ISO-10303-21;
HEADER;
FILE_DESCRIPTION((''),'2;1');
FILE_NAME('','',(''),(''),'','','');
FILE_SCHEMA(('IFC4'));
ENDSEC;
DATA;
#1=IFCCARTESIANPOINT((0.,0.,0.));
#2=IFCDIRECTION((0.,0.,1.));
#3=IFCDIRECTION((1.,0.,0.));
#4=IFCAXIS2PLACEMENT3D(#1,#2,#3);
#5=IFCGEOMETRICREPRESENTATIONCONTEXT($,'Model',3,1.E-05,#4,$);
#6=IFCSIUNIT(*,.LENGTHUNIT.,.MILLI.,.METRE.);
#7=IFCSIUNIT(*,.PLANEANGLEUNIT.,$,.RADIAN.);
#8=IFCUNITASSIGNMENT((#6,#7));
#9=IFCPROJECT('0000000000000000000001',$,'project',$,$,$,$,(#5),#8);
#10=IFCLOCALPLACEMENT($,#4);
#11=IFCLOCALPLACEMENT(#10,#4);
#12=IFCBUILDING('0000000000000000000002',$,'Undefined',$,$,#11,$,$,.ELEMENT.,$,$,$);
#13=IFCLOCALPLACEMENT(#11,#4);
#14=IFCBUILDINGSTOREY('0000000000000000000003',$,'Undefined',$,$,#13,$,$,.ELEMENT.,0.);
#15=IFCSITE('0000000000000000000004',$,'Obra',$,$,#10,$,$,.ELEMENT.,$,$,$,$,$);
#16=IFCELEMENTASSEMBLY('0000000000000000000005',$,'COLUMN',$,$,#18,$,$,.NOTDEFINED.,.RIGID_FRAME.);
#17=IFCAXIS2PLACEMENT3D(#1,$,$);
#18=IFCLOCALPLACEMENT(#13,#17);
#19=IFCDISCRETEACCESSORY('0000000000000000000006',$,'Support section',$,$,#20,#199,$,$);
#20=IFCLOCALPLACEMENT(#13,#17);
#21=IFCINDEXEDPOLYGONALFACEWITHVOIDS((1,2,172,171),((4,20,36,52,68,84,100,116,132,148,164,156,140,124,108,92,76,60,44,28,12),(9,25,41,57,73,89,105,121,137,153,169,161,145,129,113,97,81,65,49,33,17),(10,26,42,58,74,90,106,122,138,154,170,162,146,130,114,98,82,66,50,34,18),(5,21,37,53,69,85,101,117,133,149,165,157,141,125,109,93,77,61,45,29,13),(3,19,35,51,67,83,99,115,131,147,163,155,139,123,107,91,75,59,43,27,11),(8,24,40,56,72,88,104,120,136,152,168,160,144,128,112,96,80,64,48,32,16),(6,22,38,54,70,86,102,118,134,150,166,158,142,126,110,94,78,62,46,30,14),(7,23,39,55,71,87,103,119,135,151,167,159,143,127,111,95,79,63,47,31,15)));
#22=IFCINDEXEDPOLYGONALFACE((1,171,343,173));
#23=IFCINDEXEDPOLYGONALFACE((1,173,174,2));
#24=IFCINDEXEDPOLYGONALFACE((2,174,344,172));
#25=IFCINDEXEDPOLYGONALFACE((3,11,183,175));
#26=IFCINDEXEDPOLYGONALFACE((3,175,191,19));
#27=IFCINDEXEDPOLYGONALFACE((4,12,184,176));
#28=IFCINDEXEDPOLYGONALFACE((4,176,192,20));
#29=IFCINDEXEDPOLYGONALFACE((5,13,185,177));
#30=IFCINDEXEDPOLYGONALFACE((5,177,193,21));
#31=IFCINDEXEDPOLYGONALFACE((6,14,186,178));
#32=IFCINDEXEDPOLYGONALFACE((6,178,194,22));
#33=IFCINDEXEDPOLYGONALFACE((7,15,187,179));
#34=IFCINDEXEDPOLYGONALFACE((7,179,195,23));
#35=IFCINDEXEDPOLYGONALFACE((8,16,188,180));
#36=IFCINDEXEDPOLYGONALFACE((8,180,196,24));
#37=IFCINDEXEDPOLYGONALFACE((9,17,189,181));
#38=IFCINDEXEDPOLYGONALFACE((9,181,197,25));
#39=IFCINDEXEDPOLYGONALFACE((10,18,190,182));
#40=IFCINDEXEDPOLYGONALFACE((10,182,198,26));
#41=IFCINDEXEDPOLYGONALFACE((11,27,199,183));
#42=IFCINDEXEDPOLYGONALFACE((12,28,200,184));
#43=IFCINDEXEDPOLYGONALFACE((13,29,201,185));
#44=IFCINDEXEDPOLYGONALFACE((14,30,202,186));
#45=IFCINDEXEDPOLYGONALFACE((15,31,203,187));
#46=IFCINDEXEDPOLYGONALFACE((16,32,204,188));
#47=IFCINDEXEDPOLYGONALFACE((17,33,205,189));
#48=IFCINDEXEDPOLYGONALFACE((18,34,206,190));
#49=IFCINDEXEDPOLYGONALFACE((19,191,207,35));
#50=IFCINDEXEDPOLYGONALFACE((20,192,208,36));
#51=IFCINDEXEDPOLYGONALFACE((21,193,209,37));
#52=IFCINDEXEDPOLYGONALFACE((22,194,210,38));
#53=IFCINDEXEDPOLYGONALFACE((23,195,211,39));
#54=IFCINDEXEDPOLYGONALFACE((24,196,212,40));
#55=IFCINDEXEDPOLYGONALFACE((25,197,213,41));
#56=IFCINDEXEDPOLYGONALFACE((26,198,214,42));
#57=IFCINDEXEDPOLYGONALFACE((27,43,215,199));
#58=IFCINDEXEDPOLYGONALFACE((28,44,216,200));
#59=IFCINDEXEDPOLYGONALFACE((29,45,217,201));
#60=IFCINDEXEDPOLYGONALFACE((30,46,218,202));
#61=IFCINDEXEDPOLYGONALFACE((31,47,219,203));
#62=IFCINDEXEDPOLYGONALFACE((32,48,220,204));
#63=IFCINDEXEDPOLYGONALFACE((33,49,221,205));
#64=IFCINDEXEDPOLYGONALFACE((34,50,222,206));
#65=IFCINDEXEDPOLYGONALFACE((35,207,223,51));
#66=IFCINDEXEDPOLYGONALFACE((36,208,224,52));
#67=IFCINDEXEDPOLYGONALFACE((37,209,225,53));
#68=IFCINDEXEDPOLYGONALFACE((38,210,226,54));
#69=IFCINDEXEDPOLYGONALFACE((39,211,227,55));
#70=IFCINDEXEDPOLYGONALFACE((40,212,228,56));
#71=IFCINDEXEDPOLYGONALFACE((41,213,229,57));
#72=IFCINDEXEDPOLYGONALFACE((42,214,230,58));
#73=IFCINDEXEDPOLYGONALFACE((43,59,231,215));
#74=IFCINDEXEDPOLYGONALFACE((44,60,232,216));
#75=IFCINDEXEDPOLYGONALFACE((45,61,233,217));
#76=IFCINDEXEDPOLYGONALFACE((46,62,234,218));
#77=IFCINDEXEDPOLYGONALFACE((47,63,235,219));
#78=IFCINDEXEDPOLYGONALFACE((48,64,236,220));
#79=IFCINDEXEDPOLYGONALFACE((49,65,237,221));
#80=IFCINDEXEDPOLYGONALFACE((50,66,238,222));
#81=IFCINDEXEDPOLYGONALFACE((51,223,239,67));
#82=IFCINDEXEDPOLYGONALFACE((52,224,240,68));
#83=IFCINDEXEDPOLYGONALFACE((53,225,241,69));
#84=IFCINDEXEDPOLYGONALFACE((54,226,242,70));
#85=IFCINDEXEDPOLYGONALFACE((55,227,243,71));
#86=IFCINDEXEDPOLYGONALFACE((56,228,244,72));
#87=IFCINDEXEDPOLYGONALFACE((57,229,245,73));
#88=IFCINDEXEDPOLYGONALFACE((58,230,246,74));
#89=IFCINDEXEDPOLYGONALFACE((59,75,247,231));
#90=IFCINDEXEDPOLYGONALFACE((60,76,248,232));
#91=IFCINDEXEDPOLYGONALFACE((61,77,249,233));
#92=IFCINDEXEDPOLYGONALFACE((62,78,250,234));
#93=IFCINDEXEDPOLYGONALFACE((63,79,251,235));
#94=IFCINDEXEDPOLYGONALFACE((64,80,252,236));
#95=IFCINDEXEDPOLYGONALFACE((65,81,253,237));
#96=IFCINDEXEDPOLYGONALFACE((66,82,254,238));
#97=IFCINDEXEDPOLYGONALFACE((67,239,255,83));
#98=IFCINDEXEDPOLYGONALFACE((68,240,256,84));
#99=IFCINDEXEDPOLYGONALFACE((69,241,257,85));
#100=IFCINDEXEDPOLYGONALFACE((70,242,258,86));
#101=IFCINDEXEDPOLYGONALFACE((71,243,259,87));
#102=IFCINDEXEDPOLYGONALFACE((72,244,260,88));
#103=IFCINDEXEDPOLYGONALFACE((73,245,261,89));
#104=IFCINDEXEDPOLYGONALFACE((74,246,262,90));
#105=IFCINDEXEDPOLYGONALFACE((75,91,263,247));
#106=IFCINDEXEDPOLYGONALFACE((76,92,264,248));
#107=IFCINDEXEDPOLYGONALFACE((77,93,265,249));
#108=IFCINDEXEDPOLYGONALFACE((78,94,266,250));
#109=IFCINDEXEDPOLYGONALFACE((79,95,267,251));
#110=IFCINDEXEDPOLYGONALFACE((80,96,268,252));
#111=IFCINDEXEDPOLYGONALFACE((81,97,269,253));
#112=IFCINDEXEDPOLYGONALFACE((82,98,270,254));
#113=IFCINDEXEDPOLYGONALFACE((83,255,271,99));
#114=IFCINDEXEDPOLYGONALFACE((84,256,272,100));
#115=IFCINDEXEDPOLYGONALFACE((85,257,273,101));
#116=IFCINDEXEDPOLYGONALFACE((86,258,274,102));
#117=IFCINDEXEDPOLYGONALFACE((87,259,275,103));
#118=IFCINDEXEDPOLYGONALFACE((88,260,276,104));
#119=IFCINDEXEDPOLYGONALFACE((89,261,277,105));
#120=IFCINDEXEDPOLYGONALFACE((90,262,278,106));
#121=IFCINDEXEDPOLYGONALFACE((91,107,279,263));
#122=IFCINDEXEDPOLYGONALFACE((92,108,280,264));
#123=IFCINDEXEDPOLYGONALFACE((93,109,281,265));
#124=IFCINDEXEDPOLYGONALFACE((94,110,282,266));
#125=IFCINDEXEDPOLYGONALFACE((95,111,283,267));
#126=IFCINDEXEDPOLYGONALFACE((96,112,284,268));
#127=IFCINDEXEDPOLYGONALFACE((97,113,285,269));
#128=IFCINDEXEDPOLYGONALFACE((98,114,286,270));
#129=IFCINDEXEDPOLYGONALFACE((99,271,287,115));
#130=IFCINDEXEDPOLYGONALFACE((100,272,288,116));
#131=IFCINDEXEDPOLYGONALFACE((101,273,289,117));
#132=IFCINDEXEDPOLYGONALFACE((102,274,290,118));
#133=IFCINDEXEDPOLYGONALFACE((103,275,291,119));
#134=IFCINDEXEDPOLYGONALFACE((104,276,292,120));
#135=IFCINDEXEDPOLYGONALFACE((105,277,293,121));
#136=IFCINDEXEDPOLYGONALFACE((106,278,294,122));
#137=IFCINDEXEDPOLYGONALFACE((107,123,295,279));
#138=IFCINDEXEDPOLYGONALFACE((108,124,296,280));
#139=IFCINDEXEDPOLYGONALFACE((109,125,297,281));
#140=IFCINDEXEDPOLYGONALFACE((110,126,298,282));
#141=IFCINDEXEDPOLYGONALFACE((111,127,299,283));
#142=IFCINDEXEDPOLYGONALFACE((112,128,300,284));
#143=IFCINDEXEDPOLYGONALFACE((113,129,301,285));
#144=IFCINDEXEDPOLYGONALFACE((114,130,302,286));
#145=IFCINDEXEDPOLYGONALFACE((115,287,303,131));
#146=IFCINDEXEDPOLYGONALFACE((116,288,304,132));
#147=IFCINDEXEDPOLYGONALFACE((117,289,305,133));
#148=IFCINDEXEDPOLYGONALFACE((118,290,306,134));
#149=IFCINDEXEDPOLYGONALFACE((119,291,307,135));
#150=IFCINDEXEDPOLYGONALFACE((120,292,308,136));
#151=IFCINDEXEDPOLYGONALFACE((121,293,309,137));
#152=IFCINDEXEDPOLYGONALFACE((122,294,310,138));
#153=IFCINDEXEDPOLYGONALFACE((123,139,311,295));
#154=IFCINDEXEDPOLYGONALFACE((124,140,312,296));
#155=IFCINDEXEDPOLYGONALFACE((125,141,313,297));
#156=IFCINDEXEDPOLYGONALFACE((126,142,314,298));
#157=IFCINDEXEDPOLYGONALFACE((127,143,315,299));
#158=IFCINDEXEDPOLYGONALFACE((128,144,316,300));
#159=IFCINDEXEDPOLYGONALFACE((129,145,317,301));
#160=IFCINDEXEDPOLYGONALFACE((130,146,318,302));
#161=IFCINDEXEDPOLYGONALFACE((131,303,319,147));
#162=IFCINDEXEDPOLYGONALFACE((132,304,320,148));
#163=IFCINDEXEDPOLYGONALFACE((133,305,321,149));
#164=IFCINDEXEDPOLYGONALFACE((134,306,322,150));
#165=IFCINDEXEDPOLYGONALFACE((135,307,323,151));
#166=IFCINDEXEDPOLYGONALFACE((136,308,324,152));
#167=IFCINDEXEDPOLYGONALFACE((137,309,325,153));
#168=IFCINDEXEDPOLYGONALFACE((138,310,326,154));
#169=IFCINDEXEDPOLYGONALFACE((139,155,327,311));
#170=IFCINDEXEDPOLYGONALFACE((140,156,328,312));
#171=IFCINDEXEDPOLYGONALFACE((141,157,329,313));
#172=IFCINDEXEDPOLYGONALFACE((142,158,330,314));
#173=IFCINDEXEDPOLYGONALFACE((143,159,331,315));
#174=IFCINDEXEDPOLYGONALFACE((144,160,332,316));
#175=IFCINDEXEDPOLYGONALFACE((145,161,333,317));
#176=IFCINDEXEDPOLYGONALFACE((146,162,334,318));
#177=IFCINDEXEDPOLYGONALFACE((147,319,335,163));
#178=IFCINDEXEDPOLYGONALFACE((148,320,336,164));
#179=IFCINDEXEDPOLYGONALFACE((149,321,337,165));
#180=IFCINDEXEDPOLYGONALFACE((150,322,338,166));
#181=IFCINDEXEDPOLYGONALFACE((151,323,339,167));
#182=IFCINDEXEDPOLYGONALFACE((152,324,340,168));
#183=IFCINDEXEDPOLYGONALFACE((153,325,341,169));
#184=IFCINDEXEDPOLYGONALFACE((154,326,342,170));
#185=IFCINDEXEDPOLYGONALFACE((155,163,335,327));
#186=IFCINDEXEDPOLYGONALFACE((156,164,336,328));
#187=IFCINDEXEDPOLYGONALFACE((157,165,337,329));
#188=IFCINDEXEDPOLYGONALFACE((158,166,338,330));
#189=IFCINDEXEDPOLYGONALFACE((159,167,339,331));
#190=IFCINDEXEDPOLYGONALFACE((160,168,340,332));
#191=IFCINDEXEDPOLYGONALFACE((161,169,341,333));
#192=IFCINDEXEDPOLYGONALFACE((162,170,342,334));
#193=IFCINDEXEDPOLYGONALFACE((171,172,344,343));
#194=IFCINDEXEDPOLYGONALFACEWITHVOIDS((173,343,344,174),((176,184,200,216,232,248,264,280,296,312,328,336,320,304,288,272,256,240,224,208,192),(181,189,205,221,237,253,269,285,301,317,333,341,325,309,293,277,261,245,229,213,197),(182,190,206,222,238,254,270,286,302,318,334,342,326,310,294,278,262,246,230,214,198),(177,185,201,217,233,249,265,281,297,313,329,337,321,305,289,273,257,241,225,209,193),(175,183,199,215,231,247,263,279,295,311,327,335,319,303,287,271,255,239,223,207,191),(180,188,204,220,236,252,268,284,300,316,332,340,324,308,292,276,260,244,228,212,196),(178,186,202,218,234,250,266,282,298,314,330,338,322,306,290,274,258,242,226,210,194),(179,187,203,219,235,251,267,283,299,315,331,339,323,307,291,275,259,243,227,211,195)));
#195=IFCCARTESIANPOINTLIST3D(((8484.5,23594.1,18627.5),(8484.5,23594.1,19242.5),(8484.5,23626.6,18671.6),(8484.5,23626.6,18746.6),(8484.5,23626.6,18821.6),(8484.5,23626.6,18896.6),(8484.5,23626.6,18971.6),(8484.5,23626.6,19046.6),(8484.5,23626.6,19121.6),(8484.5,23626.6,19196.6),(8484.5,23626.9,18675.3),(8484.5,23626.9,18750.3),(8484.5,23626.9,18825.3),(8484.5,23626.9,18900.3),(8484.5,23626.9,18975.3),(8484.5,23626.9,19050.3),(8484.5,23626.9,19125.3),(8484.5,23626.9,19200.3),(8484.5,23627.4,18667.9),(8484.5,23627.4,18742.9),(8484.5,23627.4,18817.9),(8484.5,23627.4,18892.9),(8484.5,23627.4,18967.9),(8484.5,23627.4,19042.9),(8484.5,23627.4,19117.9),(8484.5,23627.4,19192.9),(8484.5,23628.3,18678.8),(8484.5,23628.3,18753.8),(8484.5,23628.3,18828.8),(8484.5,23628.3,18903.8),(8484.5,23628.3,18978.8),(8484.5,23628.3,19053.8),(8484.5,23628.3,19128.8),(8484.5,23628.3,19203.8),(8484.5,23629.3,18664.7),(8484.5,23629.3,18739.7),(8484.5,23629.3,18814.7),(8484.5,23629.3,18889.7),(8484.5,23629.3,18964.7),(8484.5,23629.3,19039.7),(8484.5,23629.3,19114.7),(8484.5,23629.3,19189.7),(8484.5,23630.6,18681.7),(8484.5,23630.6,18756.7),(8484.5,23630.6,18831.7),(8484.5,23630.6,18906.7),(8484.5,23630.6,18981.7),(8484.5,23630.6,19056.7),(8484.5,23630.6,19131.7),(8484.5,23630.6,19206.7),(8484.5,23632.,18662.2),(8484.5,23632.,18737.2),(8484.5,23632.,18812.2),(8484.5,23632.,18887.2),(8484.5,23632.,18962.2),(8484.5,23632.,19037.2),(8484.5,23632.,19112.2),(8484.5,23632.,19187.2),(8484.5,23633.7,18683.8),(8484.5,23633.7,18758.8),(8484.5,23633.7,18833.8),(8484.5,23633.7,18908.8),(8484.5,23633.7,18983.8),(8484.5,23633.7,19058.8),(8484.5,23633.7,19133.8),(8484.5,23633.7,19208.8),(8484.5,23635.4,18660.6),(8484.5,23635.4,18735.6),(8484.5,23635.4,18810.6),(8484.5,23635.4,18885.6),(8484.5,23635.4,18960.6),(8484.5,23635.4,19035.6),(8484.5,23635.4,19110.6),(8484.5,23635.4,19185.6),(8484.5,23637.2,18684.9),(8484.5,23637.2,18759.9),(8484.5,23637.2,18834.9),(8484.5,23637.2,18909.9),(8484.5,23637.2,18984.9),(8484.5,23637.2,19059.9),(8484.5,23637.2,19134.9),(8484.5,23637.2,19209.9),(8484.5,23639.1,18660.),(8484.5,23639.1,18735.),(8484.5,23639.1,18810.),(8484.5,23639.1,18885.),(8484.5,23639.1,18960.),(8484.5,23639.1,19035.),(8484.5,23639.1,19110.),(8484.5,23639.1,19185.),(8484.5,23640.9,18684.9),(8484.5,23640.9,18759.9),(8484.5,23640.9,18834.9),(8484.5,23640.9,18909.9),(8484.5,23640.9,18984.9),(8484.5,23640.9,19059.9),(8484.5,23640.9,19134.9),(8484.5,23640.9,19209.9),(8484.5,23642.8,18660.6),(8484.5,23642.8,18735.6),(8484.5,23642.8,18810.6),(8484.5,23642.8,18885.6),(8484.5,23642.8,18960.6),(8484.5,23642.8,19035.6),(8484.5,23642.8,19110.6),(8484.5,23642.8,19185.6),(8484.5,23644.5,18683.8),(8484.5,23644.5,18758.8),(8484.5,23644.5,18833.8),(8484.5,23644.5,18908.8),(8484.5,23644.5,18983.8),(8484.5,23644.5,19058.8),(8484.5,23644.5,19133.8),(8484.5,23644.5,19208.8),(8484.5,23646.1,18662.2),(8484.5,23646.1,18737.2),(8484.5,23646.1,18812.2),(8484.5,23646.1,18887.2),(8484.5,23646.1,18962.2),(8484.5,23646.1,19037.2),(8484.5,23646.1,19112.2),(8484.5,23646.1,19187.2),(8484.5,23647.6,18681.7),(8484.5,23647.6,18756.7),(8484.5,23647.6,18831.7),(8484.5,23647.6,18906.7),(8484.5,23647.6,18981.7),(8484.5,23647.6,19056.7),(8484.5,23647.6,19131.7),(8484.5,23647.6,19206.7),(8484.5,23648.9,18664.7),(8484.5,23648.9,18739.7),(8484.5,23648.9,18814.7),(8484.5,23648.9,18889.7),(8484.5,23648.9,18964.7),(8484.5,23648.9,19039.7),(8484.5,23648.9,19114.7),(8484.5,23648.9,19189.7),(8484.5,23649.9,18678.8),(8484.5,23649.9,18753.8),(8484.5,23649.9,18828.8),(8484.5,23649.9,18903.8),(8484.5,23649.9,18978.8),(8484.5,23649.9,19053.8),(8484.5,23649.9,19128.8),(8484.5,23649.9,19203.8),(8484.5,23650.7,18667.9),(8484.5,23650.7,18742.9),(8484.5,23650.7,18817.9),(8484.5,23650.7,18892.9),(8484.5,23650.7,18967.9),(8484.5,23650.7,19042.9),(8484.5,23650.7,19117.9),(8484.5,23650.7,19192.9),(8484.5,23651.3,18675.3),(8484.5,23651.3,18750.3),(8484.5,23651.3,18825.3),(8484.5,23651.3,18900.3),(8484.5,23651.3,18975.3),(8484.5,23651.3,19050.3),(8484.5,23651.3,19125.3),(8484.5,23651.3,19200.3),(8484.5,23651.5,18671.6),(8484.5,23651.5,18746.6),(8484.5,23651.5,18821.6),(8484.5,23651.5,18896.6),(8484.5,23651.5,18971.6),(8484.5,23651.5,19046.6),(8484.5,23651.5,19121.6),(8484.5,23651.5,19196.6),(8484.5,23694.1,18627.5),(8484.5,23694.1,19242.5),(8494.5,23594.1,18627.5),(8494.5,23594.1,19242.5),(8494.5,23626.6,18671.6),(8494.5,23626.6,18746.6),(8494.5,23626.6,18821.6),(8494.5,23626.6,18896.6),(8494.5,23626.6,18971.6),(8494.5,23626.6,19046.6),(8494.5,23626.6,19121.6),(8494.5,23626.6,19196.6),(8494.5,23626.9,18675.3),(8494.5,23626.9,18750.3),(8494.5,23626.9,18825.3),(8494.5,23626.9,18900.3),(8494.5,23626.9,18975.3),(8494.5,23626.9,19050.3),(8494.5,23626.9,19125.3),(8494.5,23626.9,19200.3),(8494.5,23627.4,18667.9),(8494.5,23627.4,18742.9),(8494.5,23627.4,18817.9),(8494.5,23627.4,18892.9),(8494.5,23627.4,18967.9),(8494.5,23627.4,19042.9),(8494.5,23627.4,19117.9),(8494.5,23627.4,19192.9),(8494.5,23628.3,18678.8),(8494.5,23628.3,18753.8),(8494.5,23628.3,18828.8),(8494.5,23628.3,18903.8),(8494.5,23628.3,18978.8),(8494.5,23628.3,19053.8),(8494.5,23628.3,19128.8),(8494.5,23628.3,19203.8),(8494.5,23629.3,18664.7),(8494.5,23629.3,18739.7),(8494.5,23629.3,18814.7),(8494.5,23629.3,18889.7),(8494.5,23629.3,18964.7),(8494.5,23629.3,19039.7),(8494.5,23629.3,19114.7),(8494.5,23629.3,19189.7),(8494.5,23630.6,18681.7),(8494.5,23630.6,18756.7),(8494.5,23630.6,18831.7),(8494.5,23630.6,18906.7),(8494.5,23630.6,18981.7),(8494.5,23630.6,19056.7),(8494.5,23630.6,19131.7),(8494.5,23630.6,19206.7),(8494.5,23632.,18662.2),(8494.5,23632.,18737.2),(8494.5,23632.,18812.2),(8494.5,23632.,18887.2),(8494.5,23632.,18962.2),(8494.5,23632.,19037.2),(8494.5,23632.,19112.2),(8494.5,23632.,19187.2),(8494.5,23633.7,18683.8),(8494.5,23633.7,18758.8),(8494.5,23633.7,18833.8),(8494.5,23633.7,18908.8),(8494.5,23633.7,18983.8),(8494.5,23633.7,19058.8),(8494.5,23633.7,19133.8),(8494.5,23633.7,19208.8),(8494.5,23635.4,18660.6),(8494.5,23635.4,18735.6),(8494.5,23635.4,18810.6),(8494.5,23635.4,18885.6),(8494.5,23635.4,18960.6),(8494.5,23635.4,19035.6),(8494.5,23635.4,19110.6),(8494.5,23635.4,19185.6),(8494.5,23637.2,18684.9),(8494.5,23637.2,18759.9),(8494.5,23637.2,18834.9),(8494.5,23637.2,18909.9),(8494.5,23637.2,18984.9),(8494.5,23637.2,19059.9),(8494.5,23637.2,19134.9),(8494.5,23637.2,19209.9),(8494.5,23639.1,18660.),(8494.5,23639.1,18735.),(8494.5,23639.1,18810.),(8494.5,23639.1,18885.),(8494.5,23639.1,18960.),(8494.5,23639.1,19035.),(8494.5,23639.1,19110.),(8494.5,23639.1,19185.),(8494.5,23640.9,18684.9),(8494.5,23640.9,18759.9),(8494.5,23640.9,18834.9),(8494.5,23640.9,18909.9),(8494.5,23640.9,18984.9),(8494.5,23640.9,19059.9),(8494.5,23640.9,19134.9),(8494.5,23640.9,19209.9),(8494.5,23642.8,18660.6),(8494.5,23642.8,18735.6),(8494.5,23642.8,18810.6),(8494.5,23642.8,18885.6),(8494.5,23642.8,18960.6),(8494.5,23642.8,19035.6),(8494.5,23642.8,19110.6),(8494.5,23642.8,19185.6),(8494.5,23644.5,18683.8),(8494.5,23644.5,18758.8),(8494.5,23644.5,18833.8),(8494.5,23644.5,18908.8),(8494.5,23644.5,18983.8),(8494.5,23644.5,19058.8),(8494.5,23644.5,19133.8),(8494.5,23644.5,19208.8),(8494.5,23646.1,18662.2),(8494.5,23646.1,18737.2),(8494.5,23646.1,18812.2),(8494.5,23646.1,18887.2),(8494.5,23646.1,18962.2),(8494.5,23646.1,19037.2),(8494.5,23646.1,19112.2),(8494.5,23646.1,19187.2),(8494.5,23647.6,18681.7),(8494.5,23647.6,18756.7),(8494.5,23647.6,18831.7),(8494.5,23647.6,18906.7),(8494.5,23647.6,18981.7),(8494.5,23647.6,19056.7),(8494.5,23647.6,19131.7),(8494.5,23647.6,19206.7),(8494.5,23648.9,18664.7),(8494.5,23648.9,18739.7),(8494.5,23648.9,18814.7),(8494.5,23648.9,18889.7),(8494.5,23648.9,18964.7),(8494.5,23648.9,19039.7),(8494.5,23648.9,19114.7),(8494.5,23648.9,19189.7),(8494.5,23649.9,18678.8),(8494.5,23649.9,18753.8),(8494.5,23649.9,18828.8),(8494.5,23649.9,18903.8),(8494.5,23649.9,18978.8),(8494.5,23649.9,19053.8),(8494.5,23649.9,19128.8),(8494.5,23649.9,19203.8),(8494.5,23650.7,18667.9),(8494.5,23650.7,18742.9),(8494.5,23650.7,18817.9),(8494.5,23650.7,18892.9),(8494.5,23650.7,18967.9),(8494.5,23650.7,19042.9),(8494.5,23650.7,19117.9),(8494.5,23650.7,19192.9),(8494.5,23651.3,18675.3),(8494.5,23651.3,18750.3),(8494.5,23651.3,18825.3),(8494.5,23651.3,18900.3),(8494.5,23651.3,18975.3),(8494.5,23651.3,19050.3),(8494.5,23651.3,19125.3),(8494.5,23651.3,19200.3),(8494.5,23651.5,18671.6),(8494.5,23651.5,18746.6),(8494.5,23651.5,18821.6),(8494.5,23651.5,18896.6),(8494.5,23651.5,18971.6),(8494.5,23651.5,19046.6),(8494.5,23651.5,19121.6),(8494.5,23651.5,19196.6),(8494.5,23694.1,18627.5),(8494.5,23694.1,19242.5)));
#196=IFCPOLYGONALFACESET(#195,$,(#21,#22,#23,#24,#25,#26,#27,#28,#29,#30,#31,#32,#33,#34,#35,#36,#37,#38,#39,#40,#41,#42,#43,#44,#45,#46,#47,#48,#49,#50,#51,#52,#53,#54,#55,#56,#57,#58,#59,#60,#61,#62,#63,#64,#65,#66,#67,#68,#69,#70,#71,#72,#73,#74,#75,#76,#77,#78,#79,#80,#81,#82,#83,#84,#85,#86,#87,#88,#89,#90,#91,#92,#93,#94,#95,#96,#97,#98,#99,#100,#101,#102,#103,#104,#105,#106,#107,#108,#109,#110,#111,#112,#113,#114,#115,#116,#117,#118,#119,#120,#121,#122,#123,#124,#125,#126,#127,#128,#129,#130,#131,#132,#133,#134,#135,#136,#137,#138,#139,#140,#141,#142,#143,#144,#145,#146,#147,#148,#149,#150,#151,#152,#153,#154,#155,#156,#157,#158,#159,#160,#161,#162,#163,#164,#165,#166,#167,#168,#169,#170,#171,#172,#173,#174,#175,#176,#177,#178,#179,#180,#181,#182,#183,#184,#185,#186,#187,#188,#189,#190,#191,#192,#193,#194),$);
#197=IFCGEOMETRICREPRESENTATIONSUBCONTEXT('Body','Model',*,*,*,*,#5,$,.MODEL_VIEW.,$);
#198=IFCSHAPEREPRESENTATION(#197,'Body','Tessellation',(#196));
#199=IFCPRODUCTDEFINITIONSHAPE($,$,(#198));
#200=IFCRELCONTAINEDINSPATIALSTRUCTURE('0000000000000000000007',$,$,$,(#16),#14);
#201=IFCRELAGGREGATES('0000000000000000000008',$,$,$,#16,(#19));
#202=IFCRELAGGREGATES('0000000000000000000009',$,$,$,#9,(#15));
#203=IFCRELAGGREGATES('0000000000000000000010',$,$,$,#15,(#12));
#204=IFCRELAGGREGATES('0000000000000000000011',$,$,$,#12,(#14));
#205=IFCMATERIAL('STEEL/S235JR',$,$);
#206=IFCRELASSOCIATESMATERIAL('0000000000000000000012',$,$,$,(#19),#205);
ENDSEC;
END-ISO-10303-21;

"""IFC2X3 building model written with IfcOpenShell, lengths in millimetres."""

from ifc_helpers import new_model, si_unit, frame, origin_with_axes, origin_2d_with_axis, place, context, subcontext, project, spatial, rectangle, circle, extrude, source, transform, mapped, material, element, aggregate, save


model = new_model("IFC2X3")

# Units and contexts
model_context = context("Model", 3, precision=1e-05, world=origin_with_axes())
body_context = subcontext(model_context, "Body", "Model", "MODEL_VIEW")
ifc_project = project(units=[si_unit("LENGTHUNIT", "METRE", prefix="MILLI"), si_unit("PLANEANGLEUNIT", "RADIAN")], contexts=[model_context])

# Site, building, storey
site_placement = place(None, origin_with_axes())
site = spatial("IfcSite", under=ifc_project, at=site_placement, Name="Obra", CompositionType="ELEMENT")
building_placement = place(site_placement, origin_with_axes())
building = spatial("IfcBuilding", under=site, at=building_placement, Name="Undefined", CompositionType="ELEMENT")
storey_placement = place(building_placement, origin_with_axes())
storey = spatial("IfcBuildingStorey", under=building, at=storey_placement, Name="Undefined", CompositionType="ELEMENT", Elevation=0.0)

# Element assembly
assembly_1_placement = place(storey_placement, origin_with_axes())
assembly_1 = element("IfcElementAssembly", 1, at=assembly_1_placement, inside=storey, Name="COLUMN", AssemblyPlace="NOTDEFINED", PredefinedType="RIGID_FRAME")
ifc_material_1 = material(Name="STEEL/S235JR")

# Discrete accessory, opening
discrete_accessory_1_placement = place(assembly_1_placement, frame((8489.5, 23644.1, 18627.5), z_axis=(0.0, 0.0, 1.0), x_axis=(0.0, 1.0, 0.0)))
discrete_accessory_1 = element("IfcDiscreteAccessory", 2, at=discrete_accessory_1_placement, material=ifc_material_1, Name="Support section", context=body_context, shape_type="SweptSolid", body=[
    extrude(rectangle(XDim=10.0, YDim=100.0, at=origin_2d_with_axis()), frame((0.0, 0.0, 615.0), z_axis=(0.0, 0.0, -1.0), x_axis=(0.0, 1.0, 0.0)), (0.0, 0.0, 1.0), 615.0),
])
shared_shape_1 = source(origin_with_axes(), body_context, "Body", "SweptSolid", [
    extrude(circle(Radius=12.5, at=origin_2d_with_axis()), frame((0.0, -15.6, 0.0), z_axis=(0.0, 1.0, 0.0), x_axis=(1.0, 0.0, 0.0)), (0.0, 0.0, 1.0), 10.2),
])
opening_1_placement = place(assembly_1_placement, frame((8500.0, 23684.1, 19350.0), z_axis=(0.0, -1.0, 0.0), x_axis=(0.0, 0.0, -1.0)))
element("IfcOpeningElement", 3, at=opening_1_placement, cuts=discrete_accessory_1, ObjectType="Opening", context=body_context, shape_type="MappedRepresentation", body=[
    mapped(shared_shape_1, transform((152.5, 0.0, 45.0))),
    mapped(shared_shape_1, transform((227.5, 0.0, 45.0))),
    mapped(shared_shape_1, transform((302.5, 0.0, 45.0))),
    mapped(shared_shape_1, transform((377.5, 0.0, 45.0))),
    mapped(shared_shape_1, transform((452.5, 0.0, 45.0))),
    mapped(shared_shape_1, transform((527.5, 0.0, 45.0))),
    mapped(shared_shape_1, transform((602.5, 0.0, 45.0))),
    mapped(shared_shape_1, transform((677.5, 0.0, 45.0))),
])
aggregate(assembly_1, [discrete_accessory_1])

save(model, "model.ifc")
